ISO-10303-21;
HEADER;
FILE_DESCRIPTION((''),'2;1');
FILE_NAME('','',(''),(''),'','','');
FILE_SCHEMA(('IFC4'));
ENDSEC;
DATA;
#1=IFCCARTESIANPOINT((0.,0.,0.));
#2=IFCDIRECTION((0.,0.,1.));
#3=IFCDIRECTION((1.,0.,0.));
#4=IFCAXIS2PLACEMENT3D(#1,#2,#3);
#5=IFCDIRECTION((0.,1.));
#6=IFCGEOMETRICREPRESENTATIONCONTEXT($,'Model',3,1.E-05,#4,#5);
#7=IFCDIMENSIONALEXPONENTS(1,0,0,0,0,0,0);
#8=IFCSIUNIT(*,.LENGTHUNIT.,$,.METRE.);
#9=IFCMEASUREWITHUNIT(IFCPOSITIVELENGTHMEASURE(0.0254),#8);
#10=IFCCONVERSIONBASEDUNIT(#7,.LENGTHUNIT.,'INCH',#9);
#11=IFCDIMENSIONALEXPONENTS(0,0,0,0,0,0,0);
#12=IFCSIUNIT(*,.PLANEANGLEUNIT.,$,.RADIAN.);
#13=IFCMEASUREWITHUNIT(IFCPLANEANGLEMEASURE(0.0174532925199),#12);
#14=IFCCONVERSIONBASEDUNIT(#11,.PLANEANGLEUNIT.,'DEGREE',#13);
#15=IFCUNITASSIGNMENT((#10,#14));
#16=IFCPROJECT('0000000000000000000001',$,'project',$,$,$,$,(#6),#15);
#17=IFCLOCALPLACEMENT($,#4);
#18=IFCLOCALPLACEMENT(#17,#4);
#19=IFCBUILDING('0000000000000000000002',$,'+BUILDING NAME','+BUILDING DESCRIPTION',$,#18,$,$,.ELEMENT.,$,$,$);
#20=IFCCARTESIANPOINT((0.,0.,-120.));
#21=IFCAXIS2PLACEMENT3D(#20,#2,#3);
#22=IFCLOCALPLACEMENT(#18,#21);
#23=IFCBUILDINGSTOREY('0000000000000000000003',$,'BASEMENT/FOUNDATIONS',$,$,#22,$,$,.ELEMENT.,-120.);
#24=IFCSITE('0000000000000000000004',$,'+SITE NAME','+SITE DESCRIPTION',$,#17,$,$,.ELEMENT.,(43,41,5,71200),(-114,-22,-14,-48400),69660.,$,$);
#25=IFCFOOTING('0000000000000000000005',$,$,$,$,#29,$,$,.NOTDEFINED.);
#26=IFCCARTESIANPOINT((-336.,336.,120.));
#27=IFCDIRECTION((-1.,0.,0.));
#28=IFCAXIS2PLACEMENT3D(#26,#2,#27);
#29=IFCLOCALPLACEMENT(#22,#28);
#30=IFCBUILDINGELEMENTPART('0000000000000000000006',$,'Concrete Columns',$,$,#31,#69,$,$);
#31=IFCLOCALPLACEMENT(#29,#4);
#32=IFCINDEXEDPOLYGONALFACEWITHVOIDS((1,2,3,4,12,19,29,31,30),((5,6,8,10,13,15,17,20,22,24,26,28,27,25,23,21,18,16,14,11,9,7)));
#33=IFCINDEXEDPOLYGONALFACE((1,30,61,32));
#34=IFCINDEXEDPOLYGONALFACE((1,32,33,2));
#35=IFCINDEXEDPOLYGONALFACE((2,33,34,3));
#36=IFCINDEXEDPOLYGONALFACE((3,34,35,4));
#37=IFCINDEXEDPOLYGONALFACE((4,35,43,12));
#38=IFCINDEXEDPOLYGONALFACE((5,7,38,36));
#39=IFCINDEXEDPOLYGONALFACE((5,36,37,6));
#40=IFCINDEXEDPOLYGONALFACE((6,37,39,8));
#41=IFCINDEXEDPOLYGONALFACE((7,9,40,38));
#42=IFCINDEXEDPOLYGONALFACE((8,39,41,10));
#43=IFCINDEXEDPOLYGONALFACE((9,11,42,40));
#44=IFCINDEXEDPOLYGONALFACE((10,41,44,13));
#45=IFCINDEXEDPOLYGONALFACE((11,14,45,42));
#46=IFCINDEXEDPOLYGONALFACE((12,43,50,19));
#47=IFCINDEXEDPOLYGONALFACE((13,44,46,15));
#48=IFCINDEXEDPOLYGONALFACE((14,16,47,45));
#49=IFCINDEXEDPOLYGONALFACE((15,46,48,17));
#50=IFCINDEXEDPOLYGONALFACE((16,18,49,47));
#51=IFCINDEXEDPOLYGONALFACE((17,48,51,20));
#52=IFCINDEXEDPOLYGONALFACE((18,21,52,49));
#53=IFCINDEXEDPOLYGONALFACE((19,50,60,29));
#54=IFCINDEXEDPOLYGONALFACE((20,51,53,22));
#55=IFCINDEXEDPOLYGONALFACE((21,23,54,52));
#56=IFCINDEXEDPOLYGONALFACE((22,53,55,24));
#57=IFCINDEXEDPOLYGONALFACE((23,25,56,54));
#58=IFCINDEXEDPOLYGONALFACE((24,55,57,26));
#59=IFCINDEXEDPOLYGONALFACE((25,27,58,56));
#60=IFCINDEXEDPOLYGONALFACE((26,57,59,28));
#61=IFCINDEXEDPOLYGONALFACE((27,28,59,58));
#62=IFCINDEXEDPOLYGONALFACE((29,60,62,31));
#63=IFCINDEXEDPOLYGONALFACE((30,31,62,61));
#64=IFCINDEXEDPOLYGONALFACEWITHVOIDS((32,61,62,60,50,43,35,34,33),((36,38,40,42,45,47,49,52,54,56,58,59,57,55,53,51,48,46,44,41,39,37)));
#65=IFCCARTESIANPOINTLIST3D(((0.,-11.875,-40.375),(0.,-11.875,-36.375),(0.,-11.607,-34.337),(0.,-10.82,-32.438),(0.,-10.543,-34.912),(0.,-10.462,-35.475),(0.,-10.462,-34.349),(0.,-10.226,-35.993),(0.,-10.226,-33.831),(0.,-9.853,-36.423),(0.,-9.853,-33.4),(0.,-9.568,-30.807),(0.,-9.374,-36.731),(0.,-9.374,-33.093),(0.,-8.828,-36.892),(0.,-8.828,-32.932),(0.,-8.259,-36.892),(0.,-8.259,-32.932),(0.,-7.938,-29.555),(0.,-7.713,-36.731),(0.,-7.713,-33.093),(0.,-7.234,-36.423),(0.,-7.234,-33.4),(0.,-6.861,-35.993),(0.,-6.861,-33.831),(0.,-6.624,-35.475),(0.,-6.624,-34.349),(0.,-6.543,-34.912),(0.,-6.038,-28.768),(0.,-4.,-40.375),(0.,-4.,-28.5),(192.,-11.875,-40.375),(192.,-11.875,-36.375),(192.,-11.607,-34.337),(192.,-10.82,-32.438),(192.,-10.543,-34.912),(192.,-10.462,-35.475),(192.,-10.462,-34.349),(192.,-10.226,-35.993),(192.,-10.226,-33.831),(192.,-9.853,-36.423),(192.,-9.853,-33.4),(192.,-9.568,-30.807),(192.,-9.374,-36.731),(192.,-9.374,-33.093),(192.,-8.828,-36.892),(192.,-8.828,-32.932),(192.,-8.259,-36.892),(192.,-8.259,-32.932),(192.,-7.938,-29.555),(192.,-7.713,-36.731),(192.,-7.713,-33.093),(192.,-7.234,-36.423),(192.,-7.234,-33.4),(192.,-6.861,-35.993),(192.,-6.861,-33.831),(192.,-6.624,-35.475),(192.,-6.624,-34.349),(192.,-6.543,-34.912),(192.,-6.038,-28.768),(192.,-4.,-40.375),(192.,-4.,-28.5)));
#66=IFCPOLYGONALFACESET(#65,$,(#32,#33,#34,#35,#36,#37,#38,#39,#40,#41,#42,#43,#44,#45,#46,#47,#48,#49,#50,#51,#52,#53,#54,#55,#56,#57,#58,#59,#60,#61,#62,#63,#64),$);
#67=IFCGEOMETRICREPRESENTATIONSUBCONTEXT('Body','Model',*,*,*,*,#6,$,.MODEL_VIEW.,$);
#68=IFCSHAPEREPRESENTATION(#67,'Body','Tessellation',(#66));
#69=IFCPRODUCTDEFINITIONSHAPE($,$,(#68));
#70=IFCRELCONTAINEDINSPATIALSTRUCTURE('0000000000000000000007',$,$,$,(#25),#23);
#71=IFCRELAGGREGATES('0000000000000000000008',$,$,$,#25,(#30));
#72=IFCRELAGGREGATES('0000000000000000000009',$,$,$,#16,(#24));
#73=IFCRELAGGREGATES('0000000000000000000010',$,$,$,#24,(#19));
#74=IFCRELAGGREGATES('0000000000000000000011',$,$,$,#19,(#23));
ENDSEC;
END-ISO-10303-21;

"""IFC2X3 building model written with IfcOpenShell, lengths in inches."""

from ifc_helpers import new_model, entity, si_unit, converted_unit, point, direction, frame, frame_2d, origin_with_axes, place, context, subcontext, project, spatial, polyline, circle_curve, parameter, trimmed, segment, composite_curve, outline, extrude, element, aggregate, save


model = new_model("IFC2X3")

# Units and contexts
model_context = context("Model", 3, precision=1e-05, world=origin_with_axes(), true_north=direction((0.0, 1.0)))
body_context = subcontext(model_context, "Body", "Model", "MODEL_VIEW")
ifc_project = project(units=[converted_unit("LENGTHUNIT", "INCH", entity("IfcPositiveLengthMeasure", 0.0254), si_unit("LENGTHUNIT", "METRE"), dimensions=[1, 0, 0, 0, 0, 0, 0]), converted_unit("PLANEANGLEUNIT", "DEGREE", entity("IfcPlaneAngleMeasure", 0.0174532925199), si_unit("PLANEANGLEUNIT", "RADIAN"), dimensions=[0, 0, 0, 0, 0, 0, 0])], contexts=[model_context])

# Site, building, storey
site_placement = place(None, origin_with_axes())
site = spatial("IfcSite", under=ifc_project, at=site_placement, Name="+SITE NAME", Description="+SITE DESCRIPTION", CompositionType="ELEMENT", RefLatitude=(43, 41, 5, 71200), RefLongitude=(-114, -22, -14, -48400), RefElevation=69660.0)
building_placement = place(site_placement, origin_with_axes())
building = spatial("IfcBuilding", under=site, at=building_placement, Name="+BUILDING NAME", Description="+BUILDING DESCRIPTION", CompositionType="ELEMENT")
storey_placement = place(building_placement, frame((0.0, 0.0, -120.0), z_axis=(0.0, 0.0, 1.0), x_axis=(1.0, 0.0, 0.0)))
storey = spatial("IfcBuildingStorey", under=building, at=storey_placement, Name="BASEMENT/FOUNDATIONS", CompositionType="ELEMENT", Elevation=-120.0)

# Footing, building element part
footing_1_placement = place(storey_placement, frame((-336.0, 336.0, 120.0), z_axis=(0.0, 0.0, 1.0), x_axis=(-1.0, 0.0, 0.0)))
footing_1 = element("IfcFooting", 1, at=footing_1_placement, inside=storey, PredefinedType="NOTDEFINED")
building_element_part_1_placement = place(footing_1_placement, origin_with_axes())
building_element_part_1 = element("IfcBuildingElementPart", 2, at=building_element_part_1_placement, Name="Concrete Columns", context=body_context, shape_type="SweptSolid", body=[
    extrude(outline(composite_curve([segment(trimmed(circle_curve(frame_2d((4.0, -36.375), x_axis=(1.0, 0.0)), 7.875), [point((11.875, -36.375)), parameter(0.0)], [point((4.0, -28.5)), parameter(90.0)], True, "CARTESIAN"), True, "CONTINUOUS"), segment(polyline([(4.0, -28.5), (4.0, -40.375), (11.875, -40.375), (11.875, -36.375)]), True, "CONTINUOUS")], self_intersect=False), holes=[composite_curve([segment(trimmed(circle_curve(frame_2d((8.543, -34.912), x_axis=(-1.0, 0.0)), 2.0), [point((10.543, -34.912)), parameter(180.0)], [point((6.543, -34.912)), parameter(0.0)], False, "CARTESIAN"), True, "CONTINUOUS"), segment(trimmed(circle_curve(frame_2d((8.543, -34.912), x_axis=(1.0, 0.0)), 2.0), [point((6.543, -34.912)), parameter(180.0)], [point((10.543, -34.912)), parameter(0.0)], False, "CARTESIAN"), True, "CONTINUOUS")], self_intersect=False)]), frame((0.0, 0.0, 0.0), z_axis=(-1.0, 0.0, 0.0), x_axis=(0.0, -1.0, 0.0)), (0.0, 0.0, -1.0), 192.0),
])
aggregate(footing_1, [building_element_part_1])

save(model, "model.ifc")
